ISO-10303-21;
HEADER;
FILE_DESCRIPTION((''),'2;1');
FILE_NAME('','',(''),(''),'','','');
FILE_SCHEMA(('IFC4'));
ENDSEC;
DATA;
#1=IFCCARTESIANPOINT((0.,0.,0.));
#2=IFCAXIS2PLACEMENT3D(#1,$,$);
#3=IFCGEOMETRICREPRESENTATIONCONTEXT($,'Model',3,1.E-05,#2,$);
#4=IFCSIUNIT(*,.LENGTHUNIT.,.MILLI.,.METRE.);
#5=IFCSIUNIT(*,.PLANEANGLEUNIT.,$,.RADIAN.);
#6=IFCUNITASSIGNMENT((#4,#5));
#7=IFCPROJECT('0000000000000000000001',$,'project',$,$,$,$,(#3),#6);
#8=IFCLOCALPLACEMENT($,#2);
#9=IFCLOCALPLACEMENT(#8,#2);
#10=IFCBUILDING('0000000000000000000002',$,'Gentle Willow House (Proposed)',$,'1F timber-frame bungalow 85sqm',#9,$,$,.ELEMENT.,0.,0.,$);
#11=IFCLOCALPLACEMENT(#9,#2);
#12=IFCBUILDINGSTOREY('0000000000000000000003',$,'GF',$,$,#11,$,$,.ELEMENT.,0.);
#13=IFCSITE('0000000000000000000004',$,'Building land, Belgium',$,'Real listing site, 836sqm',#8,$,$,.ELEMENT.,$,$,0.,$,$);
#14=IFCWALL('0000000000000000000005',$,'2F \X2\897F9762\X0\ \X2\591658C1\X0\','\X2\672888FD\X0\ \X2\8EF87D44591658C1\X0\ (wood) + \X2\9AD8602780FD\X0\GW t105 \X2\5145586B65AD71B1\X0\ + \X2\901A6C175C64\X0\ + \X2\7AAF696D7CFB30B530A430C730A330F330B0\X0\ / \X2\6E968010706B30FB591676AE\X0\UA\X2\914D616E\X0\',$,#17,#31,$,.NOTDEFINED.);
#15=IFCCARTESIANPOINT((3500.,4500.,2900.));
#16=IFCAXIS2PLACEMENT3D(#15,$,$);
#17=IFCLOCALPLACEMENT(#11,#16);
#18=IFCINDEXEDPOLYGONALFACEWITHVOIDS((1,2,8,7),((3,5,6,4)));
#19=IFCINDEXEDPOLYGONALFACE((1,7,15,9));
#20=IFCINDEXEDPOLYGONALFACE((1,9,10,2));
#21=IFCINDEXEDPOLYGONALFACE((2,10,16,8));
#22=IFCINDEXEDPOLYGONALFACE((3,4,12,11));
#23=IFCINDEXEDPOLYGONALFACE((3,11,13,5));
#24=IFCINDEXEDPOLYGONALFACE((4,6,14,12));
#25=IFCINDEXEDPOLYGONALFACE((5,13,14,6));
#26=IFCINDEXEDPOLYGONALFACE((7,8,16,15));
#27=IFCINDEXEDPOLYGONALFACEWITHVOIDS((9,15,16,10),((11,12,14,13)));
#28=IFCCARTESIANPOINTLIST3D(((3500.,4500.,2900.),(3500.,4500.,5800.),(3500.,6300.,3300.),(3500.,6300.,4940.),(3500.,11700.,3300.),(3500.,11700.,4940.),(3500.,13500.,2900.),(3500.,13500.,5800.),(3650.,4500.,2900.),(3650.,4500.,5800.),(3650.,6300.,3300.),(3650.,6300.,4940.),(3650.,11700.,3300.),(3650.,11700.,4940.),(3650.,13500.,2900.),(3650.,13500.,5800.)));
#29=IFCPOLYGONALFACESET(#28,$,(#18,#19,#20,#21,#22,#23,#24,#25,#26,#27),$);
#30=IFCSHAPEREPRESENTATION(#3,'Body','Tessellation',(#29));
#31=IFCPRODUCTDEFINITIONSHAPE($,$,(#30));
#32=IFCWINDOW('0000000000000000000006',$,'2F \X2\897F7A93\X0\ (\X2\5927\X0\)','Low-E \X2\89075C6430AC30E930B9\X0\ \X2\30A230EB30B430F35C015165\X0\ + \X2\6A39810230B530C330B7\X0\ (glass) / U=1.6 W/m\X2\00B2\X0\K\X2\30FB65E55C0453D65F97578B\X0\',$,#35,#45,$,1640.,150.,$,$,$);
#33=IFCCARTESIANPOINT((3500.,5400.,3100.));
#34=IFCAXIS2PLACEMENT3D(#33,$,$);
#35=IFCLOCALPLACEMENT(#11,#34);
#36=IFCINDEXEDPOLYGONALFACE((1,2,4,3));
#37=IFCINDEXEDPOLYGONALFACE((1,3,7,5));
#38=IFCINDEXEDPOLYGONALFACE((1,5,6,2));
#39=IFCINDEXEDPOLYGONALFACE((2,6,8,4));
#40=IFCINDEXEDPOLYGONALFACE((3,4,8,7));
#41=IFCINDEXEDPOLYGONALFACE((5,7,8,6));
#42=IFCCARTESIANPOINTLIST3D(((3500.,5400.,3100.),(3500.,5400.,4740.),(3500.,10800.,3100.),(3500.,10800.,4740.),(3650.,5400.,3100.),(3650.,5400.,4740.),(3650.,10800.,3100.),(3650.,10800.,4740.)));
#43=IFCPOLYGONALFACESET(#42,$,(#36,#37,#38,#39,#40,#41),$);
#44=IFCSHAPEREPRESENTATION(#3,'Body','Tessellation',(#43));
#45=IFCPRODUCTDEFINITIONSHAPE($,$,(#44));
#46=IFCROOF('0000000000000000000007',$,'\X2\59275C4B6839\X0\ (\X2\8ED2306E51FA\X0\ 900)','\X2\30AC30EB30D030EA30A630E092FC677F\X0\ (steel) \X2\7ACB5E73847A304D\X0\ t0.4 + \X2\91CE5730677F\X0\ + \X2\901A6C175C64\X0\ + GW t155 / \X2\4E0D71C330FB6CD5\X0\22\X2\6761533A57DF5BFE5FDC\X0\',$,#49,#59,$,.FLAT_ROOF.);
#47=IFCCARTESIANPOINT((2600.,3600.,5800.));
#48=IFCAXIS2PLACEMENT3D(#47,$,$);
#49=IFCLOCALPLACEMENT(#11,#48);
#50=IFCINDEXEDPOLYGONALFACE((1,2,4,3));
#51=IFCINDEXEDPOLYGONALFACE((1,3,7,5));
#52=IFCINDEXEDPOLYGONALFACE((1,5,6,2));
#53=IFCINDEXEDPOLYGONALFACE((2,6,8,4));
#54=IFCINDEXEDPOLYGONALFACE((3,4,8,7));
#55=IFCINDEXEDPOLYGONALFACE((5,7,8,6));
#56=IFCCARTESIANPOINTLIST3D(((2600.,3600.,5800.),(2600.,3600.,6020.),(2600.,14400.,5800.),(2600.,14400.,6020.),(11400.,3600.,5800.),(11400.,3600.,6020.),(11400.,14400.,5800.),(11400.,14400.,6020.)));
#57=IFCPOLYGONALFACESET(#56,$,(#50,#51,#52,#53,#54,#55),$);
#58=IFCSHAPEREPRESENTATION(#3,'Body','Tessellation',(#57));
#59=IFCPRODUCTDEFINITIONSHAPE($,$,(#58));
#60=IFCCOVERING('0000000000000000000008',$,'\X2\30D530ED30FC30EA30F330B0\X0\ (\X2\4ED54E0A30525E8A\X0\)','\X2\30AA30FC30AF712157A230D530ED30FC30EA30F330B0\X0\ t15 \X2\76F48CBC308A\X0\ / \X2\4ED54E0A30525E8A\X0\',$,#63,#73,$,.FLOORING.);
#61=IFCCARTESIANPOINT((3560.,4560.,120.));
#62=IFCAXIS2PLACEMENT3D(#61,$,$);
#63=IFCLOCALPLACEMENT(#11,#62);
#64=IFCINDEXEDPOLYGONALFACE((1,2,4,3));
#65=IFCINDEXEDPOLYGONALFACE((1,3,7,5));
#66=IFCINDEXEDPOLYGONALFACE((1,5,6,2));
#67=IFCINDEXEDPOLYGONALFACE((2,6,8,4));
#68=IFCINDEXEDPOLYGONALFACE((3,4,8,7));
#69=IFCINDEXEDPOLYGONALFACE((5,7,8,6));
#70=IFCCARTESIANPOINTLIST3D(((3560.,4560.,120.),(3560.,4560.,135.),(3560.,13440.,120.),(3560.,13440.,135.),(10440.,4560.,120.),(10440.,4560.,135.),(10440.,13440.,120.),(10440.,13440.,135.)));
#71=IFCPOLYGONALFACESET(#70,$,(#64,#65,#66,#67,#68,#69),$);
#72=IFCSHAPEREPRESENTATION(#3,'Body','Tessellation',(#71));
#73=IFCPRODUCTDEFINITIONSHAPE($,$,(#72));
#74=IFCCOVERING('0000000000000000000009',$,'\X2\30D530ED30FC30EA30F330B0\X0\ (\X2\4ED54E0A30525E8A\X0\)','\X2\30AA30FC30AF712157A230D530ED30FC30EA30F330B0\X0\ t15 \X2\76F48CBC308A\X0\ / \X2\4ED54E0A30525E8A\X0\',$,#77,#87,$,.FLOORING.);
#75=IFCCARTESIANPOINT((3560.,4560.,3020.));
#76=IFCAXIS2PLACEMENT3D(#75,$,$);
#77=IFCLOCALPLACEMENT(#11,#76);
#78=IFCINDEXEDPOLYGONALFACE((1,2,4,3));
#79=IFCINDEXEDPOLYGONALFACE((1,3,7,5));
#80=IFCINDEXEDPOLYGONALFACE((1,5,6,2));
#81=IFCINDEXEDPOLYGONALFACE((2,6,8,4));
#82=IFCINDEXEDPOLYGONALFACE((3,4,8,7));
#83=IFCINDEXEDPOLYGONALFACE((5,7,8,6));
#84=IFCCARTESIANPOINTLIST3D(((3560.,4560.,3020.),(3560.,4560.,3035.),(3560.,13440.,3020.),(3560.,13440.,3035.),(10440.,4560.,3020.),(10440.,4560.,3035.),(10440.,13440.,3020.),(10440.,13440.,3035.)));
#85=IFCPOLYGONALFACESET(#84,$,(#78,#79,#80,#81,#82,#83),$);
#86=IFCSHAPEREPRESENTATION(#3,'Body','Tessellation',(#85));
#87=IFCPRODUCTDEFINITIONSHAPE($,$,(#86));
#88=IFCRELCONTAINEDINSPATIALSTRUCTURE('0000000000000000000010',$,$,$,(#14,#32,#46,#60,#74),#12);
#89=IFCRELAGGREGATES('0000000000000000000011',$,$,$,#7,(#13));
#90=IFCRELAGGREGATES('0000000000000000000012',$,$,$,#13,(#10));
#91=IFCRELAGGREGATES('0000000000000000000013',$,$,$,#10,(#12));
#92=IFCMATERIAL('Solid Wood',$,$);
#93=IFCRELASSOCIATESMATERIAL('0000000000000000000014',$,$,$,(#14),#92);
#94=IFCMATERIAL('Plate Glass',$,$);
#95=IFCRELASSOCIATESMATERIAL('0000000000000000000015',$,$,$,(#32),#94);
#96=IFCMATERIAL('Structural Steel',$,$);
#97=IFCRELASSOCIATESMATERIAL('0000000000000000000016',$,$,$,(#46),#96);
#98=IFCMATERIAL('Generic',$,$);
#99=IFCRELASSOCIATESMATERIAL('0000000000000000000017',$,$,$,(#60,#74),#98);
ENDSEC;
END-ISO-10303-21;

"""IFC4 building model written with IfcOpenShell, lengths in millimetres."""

from ifc_helpers import new_model, si_unit, frame, frame_2d, origin, place, context, project, spatial, rectangle, extrude, material, element, fill, save


model = new_model("IFC4")

# Units and contexts
model_context = context("Model", 3, precision=1e-05, world=origin())
ifc_project = project(units=[si_unit("LENGTHUNIT", "METRE", prefix="MILLI"), si_unit("PLANEANGLEUNIT", "RADIAN")], contexts=[model_context])

# Site, building, storey
site_placement = place(None, origin())
site = spatial("IfcSite", under=ifc_project, at=site_placement, Name="Building land, Belgium", ObjectType="Real listing site, 836sqm", CompositionType="ELEMENT", RefElevation=0.0)
building_placement = place(site_placement, origin())
building = spatial("IfcBuilding", under=site, at=building_placement, Name="Gentle Willow House (Proposed)", ObjectType="1F timber-frame bungalow 85sqm", CompositionType="ELEMENT", ElevationOfRefHeight=0.0, ElevationOfTerrain=0.0)
storey_placement = place(building_placement, origin())
storey = spatial("IfcBuildingStorey", under=building, at=storey_placement, Name="GF", CompositionType="ELEMENT", Elevation=0.0)

# Shared definitions
ifc_material_1 = material(Name="Solid Wood")
ifc_material_2 = material(Name="Generic")

# Shared definitions
ifc_material_3 = material(Name="Plate Glass")

# Wall, opening, window
wall_1_placement = place(storey_placement, frame((3500.0, 4500.0, 2900.0)))
wall_1 = element("IfcWall", 1, at=wall_1_placement, inside=storey, material=ifc_material_1, Name="2F 西面 外壁", Description="木製 軸組外壁 (wood) + 高性能GW t105 充填断熱 + 通気層 + 窯業系サイディング / 準耐火・外皮UA配慮", PredefinedType="NOTDEFINED", context=model_context, shape_type="SweptSolid", body=[
    extrude(rectangle(XDim=150.0, YDim=9000.0, at=frame_2d((75.0, 4500.0))), frame((3500.0, 4500.0, 2900.0)), (0.0, 0.0, 1.0), 2900.0),
])
opening_1_placement = place(storey_placement, frame((3500.0, 5400.0, 3100.0)))
opening_1 = element("IfcOpeningElement", 2, at=opening_1_placement, cuts=wall_1, PredefinedType="NOTDEFINED", context=model_context, shape_type="SweptSolid", body=[
    extrude(rectangle(XDim=150.0, YDim=5400.0, at=frame_2d((75.0, 2700.0))), frame((3500.0, 5400.0, 3100.0)), (0.0, 0.0, 1.0), 1640.0),
])
window_1_placement = place(storey_placement, frame((3500.0, 5400.0, 3100.0)))
window_1 = element("IfcWindow", 3, at=window_1_placement, inside=storey, material=ifc_material_3, Name="2F 西窓 (大)", Description="Low-E 複層ガラス アルゴン封入 + 樹脂サッシ (glass) / U=1.6 W/m²K・日射取得型", OverallHeight=1640.0, OverallWidth=150.0, context=model_context, shape_type="SweptSolid", body=[
    extrude(rectangle(XDim=150.0, YDim=5400.0, at=frame_2d((75.0, 2700.0))), frame((3500.0, 5400.0, 3100.0)), (0.0, 0.0, 1.0), 1640.0),
])
fill(opening_1, window_1)

# Roof
ifc_material_4 = material(Name="Structural Steel")
roof_placement = place(storey_placement, frame((2600.0, 3600.0, 5800.0)))
element("IfcRoof", 4, at=roof_placement, inside=storey, material=ifc_material_4, Name="大屋根 (軒の出 900)", Description="ガルバリウム鋼板 (steel) 立平葺き t0.4 + 野地板 + 通気層 + GW t155 / 不燃・法22条区域対応", PredefinedType="FLAT_ROOF", context=model_context, shape_type="SweptSolid", body=[
    extrude(rectangle(XDim=8800.0, YDim=10800.0, at=frame_2d((4400.0, 5400.0))), frame((2600.0, 3600.0, 5800.0)), (0.0, 0.0, 1.0), 220.0),
])

# Coverings
covering_1_placement = place(storey_placement, frame((3560.0, 4560.0, 120.0)))
element("IfcCovering", 5, at=covering_1_placement, inside=storey, material=ifc_material_2, Name="フローリング (仕上げ床)", Description="オーク無垢フローリング t15 直貼り / 仕上げ床", PredefinedType="FLOORING", context=model_context, shape_type="SweptSolid", body=[
    extrude(rectangle(XDim=6880.0, YDim=8880.0, at=frame_2d((3440.0, 4440.0))), frame((3560.0, 4560.0, 120.0)), (0.0, 0.0, 1.0), 15.0),
])
covering_2_placement = place(storey_placement, frame((3560.0, 4560.0, 3020.0)))
element("IfcCovering", 6, at=covering_2_placement, inside=storey, material=ifc_material_2, Name="フローリング (仕上げ床)", Description="オーク無垢フローリング t15 直貼り / 仕上げ床", PredefinedType="FLOORING", context=model_context, shape_type="SweptSolid", body=[
    extrude(rectangle(XDim=6880.0, YDim=8880.0, at=frame_2d((3440.0, 4440.0))), frame((3560.0, 4560.0, 3020.0)), (0.0, 0.0, 1.0), 15.0),
])

save(model, "model.ifc")
